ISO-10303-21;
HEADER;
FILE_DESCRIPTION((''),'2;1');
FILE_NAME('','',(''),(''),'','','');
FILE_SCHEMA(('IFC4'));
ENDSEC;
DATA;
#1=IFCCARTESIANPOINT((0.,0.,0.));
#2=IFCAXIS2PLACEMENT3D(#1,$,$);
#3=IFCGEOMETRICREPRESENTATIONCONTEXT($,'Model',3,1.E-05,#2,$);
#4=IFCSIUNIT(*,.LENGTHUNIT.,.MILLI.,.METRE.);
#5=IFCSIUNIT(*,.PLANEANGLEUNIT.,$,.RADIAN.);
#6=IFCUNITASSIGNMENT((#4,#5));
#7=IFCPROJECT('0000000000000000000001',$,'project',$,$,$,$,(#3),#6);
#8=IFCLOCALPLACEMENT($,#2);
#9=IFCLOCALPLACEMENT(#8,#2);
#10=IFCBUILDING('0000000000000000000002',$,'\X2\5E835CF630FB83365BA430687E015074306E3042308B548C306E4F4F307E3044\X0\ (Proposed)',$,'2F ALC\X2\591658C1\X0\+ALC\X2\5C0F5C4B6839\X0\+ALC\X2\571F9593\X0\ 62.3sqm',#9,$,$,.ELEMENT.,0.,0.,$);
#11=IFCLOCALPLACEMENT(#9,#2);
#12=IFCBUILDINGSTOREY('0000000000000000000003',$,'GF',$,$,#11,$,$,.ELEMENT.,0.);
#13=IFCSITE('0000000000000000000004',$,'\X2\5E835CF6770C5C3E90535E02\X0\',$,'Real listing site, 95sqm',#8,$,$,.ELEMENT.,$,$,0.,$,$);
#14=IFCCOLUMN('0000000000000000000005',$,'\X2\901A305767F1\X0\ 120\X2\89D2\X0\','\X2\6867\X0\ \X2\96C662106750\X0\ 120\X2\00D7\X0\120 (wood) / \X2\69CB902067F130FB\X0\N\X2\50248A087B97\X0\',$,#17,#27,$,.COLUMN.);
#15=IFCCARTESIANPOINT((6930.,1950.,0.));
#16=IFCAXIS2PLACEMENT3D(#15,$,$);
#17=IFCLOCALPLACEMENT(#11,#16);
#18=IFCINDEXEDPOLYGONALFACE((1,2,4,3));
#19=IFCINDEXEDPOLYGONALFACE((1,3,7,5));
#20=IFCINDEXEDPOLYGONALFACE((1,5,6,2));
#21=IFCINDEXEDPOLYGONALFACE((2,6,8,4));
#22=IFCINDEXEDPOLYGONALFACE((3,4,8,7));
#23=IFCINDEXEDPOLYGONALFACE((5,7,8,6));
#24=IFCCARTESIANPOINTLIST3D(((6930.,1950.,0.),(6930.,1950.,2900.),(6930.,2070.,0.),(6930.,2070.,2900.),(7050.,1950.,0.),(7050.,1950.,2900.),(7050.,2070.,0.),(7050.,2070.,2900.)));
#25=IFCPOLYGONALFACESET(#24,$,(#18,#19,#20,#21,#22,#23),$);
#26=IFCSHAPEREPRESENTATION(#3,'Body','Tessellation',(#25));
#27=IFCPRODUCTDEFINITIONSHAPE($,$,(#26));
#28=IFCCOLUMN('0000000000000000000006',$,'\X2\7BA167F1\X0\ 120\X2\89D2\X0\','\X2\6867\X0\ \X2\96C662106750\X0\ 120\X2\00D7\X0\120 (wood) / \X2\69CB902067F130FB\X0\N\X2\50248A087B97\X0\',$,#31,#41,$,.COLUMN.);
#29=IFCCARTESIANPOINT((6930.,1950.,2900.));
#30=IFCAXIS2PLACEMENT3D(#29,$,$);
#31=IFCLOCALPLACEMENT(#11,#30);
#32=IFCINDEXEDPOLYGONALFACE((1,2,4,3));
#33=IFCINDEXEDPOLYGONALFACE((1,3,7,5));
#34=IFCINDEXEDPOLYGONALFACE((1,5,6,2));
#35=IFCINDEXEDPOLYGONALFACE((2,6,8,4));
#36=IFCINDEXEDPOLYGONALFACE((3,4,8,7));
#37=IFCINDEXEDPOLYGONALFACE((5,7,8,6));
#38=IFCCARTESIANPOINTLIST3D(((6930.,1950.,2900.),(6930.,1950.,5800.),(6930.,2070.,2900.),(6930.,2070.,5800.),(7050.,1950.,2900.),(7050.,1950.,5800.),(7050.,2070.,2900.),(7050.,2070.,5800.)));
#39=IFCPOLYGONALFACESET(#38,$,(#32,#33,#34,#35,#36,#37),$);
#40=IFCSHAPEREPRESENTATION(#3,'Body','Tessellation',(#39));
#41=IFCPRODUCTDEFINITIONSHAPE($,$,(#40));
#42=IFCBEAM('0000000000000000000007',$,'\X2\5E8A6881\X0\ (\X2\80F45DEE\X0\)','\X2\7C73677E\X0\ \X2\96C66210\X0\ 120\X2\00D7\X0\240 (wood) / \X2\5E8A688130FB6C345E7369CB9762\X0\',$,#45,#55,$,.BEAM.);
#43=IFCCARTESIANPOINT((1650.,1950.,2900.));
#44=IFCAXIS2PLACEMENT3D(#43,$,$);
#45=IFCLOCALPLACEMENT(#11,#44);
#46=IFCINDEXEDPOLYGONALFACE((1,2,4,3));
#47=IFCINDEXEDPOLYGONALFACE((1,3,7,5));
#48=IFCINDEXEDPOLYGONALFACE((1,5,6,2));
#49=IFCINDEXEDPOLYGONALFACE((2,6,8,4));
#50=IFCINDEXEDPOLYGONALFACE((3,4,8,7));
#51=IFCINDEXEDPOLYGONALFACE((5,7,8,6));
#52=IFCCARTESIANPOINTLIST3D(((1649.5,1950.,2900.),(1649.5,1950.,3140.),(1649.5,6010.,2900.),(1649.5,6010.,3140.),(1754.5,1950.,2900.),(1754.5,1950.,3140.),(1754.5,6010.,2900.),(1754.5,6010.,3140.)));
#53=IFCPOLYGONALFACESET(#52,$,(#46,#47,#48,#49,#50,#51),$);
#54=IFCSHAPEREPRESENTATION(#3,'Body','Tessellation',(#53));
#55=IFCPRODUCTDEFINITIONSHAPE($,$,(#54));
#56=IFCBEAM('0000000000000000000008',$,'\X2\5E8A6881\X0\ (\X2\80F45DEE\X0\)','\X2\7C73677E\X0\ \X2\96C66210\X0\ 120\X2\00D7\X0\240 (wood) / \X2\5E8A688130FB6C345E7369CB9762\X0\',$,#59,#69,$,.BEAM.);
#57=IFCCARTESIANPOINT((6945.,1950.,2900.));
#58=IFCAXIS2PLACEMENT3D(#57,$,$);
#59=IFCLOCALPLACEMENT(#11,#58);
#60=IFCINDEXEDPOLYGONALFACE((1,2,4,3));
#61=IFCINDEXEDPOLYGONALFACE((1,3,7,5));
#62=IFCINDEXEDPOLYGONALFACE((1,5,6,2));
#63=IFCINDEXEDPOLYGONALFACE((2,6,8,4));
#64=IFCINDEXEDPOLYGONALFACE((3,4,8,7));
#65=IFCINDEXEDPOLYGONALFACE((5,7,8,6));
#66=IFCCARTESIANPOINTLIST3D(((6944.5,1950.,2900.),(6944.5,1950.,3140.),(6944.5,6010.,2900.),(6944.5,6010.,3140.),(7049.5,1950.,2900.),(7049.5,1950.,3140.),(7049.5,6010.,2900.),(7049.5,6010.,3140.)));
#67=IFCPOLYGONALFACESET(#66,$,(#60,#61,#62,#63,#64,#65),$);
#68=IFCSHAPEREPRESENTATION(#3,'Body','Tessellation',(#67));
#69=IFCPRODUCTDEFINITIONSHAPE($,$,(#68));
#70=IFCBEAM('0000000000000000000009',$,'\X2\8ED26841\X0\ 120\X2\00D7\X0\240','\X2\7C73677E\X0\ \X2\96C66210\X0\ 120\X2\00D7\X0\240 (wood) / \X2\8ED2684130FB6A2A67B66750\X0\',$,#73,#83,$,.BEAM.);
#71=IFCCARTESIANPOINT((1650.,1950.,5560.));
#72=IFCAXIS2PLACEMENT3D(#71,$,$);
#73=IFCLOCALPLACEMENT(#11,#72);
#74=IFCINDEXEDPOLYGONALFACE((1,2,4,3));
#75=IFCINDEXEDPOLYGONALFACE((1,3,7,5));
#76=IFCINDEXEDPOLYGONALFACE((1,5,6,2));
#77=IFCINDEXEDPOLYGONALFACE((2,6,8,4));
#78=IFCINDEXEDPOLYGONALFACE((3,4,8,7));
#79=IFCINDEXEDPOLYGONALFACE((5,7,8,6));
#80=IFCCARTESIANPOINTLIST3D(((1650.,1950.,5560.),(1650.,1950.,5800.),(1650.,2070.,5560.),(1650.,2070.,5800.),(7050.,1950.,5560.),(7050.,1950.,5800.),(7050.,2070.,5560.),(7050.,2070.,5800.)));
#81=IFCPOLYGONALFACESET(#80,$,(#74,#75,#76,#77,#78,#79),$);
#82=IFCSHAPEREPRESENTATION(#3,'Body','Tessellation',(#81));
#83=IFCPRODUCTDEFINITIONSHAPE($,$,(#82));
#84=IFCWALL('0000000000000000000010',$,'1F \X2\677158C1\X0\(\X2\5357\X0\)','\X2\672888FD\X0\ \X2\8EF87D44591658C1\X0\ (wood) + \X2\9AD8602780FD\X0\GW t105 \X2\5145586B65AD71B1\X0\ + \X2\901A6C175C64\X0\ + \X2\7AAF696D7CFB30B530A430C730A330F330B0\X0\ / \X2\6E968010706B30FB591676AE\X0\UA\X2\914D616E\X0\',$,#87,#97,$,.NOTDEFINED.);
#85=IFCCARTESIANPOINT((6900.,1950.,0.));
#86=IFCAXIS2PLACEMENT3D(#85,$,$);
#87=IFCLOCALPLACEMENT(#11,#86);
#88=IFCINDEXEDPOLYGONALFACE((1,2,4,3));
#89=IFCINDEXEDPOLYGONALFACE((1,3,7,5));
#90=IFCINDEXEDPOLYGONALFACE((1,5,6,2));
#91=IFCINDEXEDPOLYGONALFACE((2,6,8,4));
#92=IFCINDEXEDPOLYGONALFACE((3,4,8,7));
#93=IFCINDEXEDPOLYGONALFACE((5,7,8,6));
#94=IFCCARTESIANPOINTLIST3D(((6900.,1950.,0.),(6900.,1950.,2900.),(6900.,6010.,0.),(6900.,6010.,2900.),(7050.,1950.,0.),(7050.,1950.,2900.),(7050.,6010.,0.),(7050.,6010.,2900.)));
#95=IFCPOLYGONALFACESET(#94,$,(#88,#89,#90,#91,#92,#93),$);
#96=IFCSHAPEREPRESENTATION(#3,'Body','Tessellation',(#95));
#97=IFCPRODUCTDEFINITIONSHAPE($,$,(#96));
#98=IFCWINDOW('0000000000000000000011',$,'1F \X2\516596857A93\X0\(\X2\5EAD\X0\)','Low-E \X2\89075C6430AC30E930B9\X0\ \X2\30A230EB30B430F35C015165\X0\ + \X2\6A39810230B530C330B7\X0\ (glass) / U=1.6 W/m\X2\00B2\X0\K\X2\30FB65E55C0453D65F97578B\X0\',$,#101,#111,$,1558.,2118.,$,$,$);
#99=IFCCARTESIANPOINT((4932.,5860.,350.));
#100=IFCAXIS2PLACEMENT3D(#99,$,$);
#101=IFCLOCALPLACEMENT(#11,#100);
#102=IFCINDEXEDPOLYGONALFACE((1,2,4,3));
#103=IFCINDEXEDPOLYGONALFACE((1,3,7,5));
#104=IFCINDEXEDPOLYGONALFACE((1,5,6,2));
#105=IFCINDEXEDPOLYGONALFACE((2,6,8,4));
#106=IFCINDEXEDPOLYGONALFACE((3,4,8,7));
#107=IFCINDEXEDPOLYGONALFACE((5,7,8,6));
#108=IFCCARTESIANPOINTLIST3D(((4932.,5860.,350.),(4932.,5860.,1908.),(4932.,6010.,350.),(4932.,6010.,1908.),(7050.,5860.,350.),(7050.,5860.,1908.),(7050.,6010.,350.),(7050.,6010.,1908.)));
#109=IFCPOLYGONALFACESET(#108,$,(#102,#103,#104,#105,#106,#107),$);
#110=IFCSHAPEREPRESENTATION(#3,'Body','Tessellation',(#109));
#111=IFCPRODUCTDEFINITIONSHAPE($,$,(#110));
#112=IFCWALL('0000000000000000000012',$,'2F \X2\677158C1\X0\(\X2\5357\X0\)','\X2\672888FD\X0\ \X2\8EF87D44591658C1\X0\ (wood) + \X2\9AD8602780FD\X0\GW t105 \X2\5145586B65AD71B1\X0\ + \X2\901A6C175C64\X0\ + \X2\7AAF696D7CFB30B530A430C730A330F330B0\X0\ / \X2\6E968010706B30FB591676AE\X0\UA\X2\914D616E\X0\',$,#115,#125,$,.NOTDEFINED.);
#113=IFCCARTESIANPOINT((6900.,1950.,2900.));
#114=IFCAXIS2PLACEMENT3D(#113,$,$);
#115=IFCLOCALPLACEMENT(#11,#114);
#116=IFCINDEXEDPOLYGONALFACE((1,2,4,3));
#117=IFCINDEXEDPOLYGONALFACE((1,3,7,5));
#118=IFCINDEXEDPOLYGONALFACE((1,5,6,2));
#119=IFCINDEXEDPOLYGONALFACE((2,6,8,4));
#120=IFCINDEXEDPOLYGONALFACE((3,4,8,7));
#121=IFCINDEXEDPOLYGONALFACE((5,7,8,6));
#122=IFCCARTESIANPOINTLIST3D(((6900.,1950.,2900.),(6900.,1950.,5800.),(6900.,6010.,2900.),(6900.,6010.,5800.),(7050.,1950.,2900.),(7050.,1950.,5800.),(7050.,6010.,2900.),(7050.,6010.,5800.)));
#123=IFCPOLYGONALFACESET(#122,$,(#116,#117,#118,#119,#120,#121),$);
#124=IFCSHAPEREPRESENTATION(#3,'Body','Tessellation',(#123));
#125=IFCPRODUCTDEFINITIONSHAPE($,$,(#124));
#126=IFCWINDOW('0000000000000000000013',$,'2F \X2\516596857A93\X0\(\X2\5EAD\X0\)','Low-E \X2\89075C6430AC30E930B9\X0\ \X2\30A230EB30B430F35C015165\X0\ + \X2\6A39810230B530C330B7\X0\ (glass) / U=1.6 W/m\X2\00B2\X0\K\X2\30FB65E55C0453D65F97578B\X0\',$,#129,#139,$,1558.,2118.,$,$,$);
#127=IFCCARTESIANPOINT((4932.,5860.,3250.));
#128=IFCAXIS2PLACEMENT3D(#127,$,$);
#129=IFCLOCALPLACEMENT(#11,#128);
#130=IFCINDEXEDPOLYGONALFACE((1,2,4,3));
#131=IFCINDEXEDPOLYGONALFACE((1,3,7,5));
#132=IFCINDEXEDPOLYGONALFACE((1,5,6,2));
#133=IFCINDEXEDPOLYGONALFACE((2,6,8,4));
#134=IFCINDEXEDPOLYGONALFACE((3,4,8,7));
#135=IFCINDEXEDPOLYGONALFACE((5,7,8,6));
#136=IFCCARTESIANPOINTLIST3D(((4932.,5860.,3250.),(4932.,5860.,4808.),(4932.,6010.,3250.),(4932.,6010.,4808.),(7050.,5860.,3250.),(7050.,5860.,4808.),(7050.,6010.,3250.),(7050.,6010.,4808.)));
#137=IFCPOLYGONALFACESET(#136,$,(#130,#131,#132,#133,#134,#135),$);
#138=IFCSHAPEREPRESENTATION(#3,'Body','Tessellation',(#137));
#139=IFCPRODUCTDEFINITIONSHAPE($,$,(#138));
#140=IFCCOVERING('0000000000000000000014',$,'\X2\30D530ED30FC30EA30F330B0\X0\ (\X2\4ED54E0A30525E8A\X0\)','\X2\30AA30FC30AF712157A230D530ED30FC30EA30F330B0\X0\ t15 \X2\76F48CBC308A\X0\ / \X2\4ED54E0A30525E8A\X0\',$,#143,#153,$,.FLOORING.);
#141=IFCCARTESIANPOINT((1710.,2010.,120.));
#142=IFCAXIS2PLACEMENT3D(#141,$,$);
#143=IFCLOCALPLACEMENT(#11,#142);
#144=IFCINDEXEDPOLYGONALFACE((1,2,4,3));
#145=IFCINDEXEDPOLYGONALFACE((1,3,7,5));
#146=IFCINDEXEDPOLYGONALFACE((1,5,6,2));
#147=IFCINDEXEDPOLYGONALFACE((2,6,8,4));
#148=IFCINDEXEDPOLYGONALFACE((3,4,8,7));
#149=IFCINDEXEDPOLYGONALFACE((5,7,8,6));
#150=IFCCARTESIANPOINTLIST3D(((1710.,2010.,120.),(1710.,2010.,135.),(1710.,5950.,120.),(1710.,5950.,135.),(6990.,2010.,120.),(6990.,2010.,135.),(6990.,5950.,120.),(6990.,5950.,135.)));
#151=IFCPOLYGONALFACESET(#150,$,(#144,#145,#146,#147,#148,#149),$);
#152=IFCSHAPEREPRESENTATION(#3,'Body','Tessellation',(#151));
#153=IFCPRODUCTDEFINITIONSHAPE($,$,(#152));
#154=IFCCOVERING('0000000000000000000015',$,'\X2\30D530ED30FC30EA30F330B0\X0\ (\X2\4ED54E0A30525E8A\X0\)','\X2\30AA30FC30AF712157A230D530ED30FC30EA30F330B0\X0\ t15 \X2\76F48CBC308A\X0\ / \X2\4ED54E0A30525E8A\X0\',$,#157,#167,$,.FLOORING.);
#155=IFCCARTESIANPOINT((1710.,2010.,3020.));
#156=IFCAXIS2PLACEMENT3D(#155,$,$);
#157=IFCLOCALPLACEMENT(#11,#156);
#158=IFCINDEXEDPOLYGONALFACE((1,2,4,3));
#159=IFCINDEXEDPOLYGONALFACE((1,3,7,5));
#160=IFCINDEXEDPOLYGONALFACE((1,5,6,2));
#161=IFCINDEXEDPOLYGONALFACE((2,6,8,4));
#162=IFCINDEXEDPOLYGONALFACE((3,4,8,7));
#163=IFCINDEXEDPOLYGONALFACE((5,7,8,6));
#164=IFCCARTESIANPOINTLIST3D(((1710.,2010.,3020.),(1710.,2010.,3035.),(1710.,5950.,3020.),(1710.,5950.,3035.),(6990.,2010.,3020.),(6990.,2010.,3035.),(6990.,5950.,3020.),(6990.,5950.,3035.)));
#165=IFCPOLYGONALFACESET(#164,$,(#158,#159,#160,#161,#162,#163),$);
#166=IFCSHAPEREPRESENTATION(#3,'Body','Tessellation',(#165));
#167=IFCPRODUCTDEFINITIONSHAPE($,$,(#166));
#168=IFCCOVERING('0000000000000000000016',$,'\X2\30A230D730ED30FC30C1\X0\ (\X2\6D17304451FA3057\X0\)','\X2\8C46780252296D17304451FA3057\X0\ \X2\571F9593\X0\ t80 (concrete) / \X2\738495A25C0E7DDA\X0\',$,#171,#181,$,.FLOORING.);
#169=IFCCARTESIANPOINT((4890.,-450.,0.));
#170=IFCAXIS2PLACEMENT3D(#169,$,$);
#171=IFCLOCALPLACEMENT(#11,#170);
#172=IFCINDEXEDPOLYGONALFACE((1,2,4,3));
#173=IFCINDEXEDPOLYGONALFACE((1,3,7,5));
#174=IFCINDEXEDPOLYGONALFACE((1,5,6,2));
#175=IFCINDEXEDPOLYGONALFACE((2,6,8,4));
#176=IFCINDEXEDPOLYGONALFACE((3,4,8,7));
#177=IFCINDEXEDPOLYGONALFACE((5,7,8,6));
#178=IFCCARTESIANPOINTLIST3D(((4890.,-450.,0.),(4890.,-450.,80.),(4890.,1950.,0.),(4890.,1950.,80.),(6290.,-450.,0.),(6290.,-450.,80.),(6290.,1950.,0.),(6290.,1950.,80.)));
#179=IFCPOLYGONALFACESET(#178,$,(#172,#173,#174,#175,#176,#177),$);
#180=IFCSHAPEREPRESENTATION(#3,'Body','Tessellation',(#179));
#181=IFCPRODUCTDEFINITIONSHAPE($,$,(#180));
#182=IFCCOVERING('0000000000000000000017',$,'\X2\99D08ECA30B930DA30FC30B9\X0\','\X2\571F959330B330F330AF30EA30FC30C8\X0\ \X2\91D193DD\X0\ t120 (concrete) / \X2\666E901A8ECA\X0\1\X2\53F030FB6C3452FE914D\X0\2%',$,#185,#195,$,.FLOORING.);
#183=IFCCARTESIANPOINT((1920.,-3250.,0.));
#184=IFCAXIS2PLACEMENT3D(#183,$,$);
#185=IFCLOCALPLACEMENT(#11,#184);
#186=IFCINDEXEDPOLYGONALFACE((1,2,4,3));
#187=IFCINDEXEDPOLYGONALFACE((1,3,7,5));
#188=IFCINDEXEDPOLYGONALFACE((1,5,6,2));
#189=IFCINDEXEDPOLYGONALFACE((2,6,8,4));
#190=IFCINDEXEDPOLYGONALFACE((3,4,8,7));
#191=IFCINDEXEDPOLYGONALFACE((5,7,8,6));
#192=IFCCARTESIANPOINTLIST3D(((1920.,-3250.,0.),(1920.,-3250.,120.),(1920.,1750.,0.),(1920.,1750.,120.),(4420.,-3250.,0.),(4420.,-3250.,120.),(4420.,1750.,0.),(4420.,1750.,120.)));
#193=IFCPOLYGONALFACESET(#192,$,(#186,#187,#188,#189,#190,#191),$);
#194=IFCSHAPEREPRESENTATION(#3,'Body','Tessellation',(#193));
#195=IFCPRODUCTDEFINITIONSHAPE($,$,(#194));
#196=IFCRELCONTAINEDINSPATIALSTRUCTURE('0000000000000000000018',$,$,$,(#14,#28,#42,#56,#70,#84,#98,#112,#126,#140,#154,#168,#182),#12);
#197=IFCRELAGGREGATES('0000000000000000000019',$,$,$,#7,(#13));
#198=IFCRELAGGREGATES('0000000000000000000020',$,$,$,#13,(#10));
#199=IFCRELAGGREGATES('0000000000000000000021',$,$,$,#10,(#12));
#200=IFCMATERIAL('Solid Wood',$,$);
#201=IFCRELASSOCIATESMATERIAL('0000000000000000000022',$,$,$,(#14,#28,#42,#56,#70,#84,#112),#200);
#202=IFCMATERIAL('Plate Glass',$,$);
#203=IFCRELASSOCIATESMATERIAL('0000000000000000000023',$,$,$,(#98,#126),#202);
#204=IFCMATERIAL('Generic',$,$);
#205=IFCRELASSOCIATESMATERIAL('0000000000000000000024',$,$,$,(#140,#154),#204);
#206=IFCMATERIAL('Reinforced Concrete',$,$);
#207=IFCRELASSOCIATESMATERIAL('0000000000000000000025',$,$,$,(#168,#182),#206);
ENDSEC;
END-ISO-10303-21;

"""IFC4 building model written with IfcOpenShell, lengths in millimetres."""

from ifc_helpers import new_model, si_unit, frame, frame_2d, origin, place, context, project, spatial, rectangle, extrude, material, element, fill, save


model = new_model("IFC4")

# Units and contexts
model_context = context("Model", 3, precision=1e-05, world=origin())
ifc_project = project(units=[si_unit("LENGTHUNIT", "METRE", prefix="MILLI"), si_unit("PLANEANGLEUNIT", "RADIAN")], contexts=[model_context])

# Site, building, storey
site_placement = place(None, origin())
site = spatial("IfcSite", under=ifc_project, at=site_placement, Name="広島県尾道市", ObjectType="Real listing site, 95sqm", CompositionType="ELEMENT", RefElevation=0.0)
building_placement = place(site_placement, origin())
building = spatial("IfcBuilding", under=site, at=building_placement, Name="広島・茶室と縁側のある和の住まい (Proposed)", ObjectType="2F ALC外壁+ALC小屋根+ALC土間 62.3sqm", CompositionType="ELEMENT", ElevationOfRefHeight=0.0, ElevationOfTerrain=0.0)
storey_placement = place(building_placement, origin())
storey = spatial("IfcBuildingStorey", under=building, at=storey_placement, Name="GF", CompositionType="ELEMENT", Elevation=0.0)

# Columns
ifc_material_1 = material(Name="Solid Wood")
column_1_placement = place(storey_placement, frame((6930.0, 1950.0, 0.0)))
element("IfcColumn", 1, at=column_1_placement, inside=storey, material=ifc_material_1, Name="通し柱 120角", Description="桧 集成材 120×120 (wood) / 構造柱・N値計算", PredefinedType="COLUMN", context=model_context, shape_type="SweptSolid", body=[
    extrude(rectangle(XDim=120.0, YDim=120.0, at=frame_2d((60.0, 60.0))), frame((6930.0, 1950.0, 0.0)), (0.0, 0.0, 1.0), 2900.0),
])
column_2_placement = place(storey_placement, frame((6930.0, 1950.0, 2900.0)))
element("IfcColumn", 2, at=column_2_placement, inside=storey, material=ifc_material_1, Name="管柱 120角", Description="桧 集成材 120×120 (wood) / 構造柱・N値計算", PredefinedType="COLUMN", context=model_context, shape_type="SweptSolid", body=[
    extrude(rectangle(XDim=120.0, YDim=120.0, at=frame_2d((60.0, 60.0))), frame((6930.0, 1950.0, 2900.0)), (0.0, 0.0, 1.0), 2900.0),
])

# Beams
beam_1_placement = place(storey_placement, frame((1650.0, 1950.0, 2900.0)))
element("IfcBeam", 3, at=beam_1_placement, inside=storey, material=ifc_material_1, Name="床梁 (胴差)", Description="米松 集成 120×240 (wood) / 床梁・水平構面", PredefinedType="BEAM", context=model_context, shape_type="SweptSolid", body=[
    extrude(rectangle(XDim=105.0, YDim=4060.0, at=frame_2d((52.0, 2030.0))), frame((1650.0, 1950.0, 2900.0)), (0.0, 0.0, 1.0), 240.0),
])
beam_2_placement = place(storey_placement, frame((6945.0, 1950.0, 2900.0)))
element("IfcBeam", 4, at=beam_2_placement, inside=storey, material=ifc_material_1, Name="床梁 (胴差)", Description="米松 集成 120×240 (wood) / 床梁・水平構面", PredefinedType="BEAM", context=model_context, shape_type="SweptSolid", body=[
    extrude(rectangle(XDim=105.0, YDim=4060.0, at=frame_2d((52.0, 2030.0))), frame((6945.0, 1950.0, 2900.0)), (0.0, 0.0, 1.0), 240.0),
])
beam_3_placement = place(storey_placement, frame((1650.0, 1950.0, 5560.0)))
element("IfcBeam", 5, at=beam_3_placement, inside=storey, material=ifc_material_1, Name="軒桁 120×240", Description="米松 集成 120×240 (wood) / 軒桁・横架材", PredefinedType="BEAM", context=model_context, shape_type="SweptSolid", body=[
    extrude(rectangle(XDim=5400.0, YDim=120.0, at=frame_2d((2700.0, 60.0))), frame((1650.0, 1950.0, 5560.0)), (0.0, 0.0, 1.0), 240.0),
])

# Wall, opening, window
wall_1_placement = place(storey_placement, frame((6900.0, 1950.0, 0.0)))
wall_1 = element("IfcWall", 6, at=wall_1_placement, inside=storey, material=ifc_material_1, Name="1F 東壁(南)", Description="木製 軸組外壁 (wood) + 高性能GW t105 充填断熱 + 通気層 + 窯業系サイディング / 準耐火・外皮UA配慮", PredefinedType="NOTDEFINED", context=model_context, shape_type="SweptSolid", body=[
    extrude(rectangle(XDim=150.0, YDim=4060.0, at=frame_2d((75.0, 2030.0))), frame((6900.0, 1950.0, 0.0)), (0.0, 0.0, 1.0), 2900.0),
])
opening_1_placement = place(storey_placement, frame((4932.0, 5860.0, 350.0)))
opening_1 = element("IfcOpeningElement", 7, at=opening_1_placement, cuts=wall_1, PredefinedType="NOTDEFINED", context=model_context, shape_type="SweptSolid", body=[
    extrude(rectangle(XDim=2118.0, YDim=150.0, at=frame_2d((1059.0, 75.0))), frame((4932.0, 5860.0, 350.0)), (0.0, 0.0, 1.0), 1558.0),
])
ifc_material_2 = material(Name="Plate Glass")
window_1_placement = place(storey_placement, frame((4932.0, 5860.0, 350.0)))
window_1 = element("IfcWindow", 8, at=window_1_placement, inside=storey, material=ifc_material_2, Name="1F 入隅窓(庭)", Description="Low-E 複層ガラス アルゴン封入 + 樹脂サッシ (glass) / U=1.6 W/m²K・日射取得型", OverallHeight=1558.0, OverallWidth=2118.0, context=model_context, shape_type="SweptSolid", body=[
    extrude(rectangle(XDim=2118.0, YDim=150.0, at=frame_2d((1059.0, 75.0))), frame((4932.0, 5860.0, 350.0)), (0.0, 0.0, 1.0), 1558.0),
])
fill(opening_1, window_1)

# Wall, opening, window
wall_2_placement = place(storey_placement, frame((6900.0, 1950.0, 2900.0)))
wall_2 = element("IfcWall", 9, at=wall_2_placement, inside=storey, material=ifc_material_1, Name="2F 東壁(南)", Description="木製 軸組外壁 (wood) + 高性能GW t105 充填断熱 + 通気層 + 窯業系サイディング / 準耐火・外皮UA配慮", PredefinedType="NOTDEFINED", context=model_context, shape_type="SweptSolid", body=[
    extrude(rectangle(XDim=150.0, YDim=4060.0, at=frame_2d((75.0, 2030.0))), frame((6900.0, 1950.0, 2900.0)), (0.0, 0.0, 1.0), 2900.0),
])
opening_2_placement = place(storey_placement, frame((4932.0, 5860.0, 3250.0)))
opening_2 = element("IfcOpeningElement", 10, at=opening_2_placement, cuts=wall_2, PredefinedType="NOTDEFINED", context=model_context, shape_type="SweptSolid", body=[
    extrude(rectangle(XDim=2118.0, YDim=150.0, at=frame_2d((1059.0, 75.0))), frame((4932.0, 5860.0, 3250.0)), (0.0, 0.0, 1.0), 1558.0),
])
window_2_placement = place(storey_placement, frame((4932.0, 5860.0, 3250.0)))
window_2 = element("IfcWindow", 11, at=window_2_placement, inside=storey, material=ifc_material_2, Name="2F 入隅窓(庭)", Description="Low-E 複層ガラス アルゴン封入 + 樹脂サッシ (glass) / U=1.6 W/m²K・日射取得型", OverallHeight=1558.0, OverallWidth=2118.0, context=model_context, shape_type="SweptSolid", body=[
    extrude(rectangle(XDim=2118.0, YDim=150.0, at=frame_2d((1059.0, 75.0))), frame((4932.0, 5860.0, 3250.0)), (0.0, 0.0, 1.0), 1558.0),
])
fill(opening_2, window_2)

# Coverings
ifc_material_3 = material(Name="Generic")
covering_1_placement = place(storey_placement, frame((1710.0, 2010.0, 120.0)))
element("IfcCovering", 12, at=covering_1_placement, inside=storey, material=ifc_material_3, Name="フローリング (仕上げ床)", Description="オーク無垢フローリング t15 直貼り / 仕上げ床", PredefinedType="FLOORING", context=model_context, shape_type="SweptSolid", body=[
    extrude(rectangle(XDim=5280.0, YDim=3940.0, at=frame_2d((2640.0, 1970.0))), frame((1710.0, 2010.0, 120.0)), (0.0, 0.0, 1.0), 15.0),
])
covering_2_placement = place(storey_placement, frame((1710.0, 2010.0, 3020.0)))
element("IfcCovering", 13, at=covering_2_placement, inside=storey, material=ifc_material_3, Name="フローリング (仕上げ床)", Description="オーク無垢フローリング t15 直貼り / 仕上げ床", PredefinedType="FLOORING", context=model_context, shape_type="SweptSolid", body=[
    extrude(rectangle(XDim=5280.0, YDim=3940.0, at=frame_2d((2640.0, 1970.0))), frame((1710.0, 2010.0, 3020.0)), (0.0, 0.0, 1.0), 15.0),
])
ifc_material_4 = material(Name="Reinforced Concrete")
covering_3_placement = place(storey_placement, frame((4890.0, -450.0, 0.0)))
element("IfcCovering", 14, at=covering_3_placement, inside=storey, material=ifc_material_4, Name="アプローチ (洗い出し)", Description="豆砂利洗い出し 土間 t80 (concrete) / 玄関導線", PredefinedType="FLOORING", context=model_context, shape_type="SweptSolid", body=[
    extrude(rectangle(XDim=1400.0, YDim=2400.0, at=frame_2d((700.0, 1200.0))), frame((4890.0, -450.0, 0.0)), (0.0, 0.0, 1.0), 80.0),
])
covering_4_placement = place(storey_placement, frame((1920.0, -3250.0, 0.0)))
element("IfcCovering", 15, at=covering_4_placement, inside=storey, material=ifc_material_4, Name="駐車スペース", Description="土間コンクリート 金鏝 t120 (concrete) / 普通車1台・水勾配2%", PredefinedType="FLOORING", context=model_context, shape_type="SweptSolid", body=[
    extrude(rectangle(XDim=2500.0, YDim=5000.0, at=frame_2d((1250.0, 2500.0))), frame((1920.0, -3250.0, 0.0)), (0.0, 0.0, 1.0), 120.0),
])

save(model, "model.ifc")
